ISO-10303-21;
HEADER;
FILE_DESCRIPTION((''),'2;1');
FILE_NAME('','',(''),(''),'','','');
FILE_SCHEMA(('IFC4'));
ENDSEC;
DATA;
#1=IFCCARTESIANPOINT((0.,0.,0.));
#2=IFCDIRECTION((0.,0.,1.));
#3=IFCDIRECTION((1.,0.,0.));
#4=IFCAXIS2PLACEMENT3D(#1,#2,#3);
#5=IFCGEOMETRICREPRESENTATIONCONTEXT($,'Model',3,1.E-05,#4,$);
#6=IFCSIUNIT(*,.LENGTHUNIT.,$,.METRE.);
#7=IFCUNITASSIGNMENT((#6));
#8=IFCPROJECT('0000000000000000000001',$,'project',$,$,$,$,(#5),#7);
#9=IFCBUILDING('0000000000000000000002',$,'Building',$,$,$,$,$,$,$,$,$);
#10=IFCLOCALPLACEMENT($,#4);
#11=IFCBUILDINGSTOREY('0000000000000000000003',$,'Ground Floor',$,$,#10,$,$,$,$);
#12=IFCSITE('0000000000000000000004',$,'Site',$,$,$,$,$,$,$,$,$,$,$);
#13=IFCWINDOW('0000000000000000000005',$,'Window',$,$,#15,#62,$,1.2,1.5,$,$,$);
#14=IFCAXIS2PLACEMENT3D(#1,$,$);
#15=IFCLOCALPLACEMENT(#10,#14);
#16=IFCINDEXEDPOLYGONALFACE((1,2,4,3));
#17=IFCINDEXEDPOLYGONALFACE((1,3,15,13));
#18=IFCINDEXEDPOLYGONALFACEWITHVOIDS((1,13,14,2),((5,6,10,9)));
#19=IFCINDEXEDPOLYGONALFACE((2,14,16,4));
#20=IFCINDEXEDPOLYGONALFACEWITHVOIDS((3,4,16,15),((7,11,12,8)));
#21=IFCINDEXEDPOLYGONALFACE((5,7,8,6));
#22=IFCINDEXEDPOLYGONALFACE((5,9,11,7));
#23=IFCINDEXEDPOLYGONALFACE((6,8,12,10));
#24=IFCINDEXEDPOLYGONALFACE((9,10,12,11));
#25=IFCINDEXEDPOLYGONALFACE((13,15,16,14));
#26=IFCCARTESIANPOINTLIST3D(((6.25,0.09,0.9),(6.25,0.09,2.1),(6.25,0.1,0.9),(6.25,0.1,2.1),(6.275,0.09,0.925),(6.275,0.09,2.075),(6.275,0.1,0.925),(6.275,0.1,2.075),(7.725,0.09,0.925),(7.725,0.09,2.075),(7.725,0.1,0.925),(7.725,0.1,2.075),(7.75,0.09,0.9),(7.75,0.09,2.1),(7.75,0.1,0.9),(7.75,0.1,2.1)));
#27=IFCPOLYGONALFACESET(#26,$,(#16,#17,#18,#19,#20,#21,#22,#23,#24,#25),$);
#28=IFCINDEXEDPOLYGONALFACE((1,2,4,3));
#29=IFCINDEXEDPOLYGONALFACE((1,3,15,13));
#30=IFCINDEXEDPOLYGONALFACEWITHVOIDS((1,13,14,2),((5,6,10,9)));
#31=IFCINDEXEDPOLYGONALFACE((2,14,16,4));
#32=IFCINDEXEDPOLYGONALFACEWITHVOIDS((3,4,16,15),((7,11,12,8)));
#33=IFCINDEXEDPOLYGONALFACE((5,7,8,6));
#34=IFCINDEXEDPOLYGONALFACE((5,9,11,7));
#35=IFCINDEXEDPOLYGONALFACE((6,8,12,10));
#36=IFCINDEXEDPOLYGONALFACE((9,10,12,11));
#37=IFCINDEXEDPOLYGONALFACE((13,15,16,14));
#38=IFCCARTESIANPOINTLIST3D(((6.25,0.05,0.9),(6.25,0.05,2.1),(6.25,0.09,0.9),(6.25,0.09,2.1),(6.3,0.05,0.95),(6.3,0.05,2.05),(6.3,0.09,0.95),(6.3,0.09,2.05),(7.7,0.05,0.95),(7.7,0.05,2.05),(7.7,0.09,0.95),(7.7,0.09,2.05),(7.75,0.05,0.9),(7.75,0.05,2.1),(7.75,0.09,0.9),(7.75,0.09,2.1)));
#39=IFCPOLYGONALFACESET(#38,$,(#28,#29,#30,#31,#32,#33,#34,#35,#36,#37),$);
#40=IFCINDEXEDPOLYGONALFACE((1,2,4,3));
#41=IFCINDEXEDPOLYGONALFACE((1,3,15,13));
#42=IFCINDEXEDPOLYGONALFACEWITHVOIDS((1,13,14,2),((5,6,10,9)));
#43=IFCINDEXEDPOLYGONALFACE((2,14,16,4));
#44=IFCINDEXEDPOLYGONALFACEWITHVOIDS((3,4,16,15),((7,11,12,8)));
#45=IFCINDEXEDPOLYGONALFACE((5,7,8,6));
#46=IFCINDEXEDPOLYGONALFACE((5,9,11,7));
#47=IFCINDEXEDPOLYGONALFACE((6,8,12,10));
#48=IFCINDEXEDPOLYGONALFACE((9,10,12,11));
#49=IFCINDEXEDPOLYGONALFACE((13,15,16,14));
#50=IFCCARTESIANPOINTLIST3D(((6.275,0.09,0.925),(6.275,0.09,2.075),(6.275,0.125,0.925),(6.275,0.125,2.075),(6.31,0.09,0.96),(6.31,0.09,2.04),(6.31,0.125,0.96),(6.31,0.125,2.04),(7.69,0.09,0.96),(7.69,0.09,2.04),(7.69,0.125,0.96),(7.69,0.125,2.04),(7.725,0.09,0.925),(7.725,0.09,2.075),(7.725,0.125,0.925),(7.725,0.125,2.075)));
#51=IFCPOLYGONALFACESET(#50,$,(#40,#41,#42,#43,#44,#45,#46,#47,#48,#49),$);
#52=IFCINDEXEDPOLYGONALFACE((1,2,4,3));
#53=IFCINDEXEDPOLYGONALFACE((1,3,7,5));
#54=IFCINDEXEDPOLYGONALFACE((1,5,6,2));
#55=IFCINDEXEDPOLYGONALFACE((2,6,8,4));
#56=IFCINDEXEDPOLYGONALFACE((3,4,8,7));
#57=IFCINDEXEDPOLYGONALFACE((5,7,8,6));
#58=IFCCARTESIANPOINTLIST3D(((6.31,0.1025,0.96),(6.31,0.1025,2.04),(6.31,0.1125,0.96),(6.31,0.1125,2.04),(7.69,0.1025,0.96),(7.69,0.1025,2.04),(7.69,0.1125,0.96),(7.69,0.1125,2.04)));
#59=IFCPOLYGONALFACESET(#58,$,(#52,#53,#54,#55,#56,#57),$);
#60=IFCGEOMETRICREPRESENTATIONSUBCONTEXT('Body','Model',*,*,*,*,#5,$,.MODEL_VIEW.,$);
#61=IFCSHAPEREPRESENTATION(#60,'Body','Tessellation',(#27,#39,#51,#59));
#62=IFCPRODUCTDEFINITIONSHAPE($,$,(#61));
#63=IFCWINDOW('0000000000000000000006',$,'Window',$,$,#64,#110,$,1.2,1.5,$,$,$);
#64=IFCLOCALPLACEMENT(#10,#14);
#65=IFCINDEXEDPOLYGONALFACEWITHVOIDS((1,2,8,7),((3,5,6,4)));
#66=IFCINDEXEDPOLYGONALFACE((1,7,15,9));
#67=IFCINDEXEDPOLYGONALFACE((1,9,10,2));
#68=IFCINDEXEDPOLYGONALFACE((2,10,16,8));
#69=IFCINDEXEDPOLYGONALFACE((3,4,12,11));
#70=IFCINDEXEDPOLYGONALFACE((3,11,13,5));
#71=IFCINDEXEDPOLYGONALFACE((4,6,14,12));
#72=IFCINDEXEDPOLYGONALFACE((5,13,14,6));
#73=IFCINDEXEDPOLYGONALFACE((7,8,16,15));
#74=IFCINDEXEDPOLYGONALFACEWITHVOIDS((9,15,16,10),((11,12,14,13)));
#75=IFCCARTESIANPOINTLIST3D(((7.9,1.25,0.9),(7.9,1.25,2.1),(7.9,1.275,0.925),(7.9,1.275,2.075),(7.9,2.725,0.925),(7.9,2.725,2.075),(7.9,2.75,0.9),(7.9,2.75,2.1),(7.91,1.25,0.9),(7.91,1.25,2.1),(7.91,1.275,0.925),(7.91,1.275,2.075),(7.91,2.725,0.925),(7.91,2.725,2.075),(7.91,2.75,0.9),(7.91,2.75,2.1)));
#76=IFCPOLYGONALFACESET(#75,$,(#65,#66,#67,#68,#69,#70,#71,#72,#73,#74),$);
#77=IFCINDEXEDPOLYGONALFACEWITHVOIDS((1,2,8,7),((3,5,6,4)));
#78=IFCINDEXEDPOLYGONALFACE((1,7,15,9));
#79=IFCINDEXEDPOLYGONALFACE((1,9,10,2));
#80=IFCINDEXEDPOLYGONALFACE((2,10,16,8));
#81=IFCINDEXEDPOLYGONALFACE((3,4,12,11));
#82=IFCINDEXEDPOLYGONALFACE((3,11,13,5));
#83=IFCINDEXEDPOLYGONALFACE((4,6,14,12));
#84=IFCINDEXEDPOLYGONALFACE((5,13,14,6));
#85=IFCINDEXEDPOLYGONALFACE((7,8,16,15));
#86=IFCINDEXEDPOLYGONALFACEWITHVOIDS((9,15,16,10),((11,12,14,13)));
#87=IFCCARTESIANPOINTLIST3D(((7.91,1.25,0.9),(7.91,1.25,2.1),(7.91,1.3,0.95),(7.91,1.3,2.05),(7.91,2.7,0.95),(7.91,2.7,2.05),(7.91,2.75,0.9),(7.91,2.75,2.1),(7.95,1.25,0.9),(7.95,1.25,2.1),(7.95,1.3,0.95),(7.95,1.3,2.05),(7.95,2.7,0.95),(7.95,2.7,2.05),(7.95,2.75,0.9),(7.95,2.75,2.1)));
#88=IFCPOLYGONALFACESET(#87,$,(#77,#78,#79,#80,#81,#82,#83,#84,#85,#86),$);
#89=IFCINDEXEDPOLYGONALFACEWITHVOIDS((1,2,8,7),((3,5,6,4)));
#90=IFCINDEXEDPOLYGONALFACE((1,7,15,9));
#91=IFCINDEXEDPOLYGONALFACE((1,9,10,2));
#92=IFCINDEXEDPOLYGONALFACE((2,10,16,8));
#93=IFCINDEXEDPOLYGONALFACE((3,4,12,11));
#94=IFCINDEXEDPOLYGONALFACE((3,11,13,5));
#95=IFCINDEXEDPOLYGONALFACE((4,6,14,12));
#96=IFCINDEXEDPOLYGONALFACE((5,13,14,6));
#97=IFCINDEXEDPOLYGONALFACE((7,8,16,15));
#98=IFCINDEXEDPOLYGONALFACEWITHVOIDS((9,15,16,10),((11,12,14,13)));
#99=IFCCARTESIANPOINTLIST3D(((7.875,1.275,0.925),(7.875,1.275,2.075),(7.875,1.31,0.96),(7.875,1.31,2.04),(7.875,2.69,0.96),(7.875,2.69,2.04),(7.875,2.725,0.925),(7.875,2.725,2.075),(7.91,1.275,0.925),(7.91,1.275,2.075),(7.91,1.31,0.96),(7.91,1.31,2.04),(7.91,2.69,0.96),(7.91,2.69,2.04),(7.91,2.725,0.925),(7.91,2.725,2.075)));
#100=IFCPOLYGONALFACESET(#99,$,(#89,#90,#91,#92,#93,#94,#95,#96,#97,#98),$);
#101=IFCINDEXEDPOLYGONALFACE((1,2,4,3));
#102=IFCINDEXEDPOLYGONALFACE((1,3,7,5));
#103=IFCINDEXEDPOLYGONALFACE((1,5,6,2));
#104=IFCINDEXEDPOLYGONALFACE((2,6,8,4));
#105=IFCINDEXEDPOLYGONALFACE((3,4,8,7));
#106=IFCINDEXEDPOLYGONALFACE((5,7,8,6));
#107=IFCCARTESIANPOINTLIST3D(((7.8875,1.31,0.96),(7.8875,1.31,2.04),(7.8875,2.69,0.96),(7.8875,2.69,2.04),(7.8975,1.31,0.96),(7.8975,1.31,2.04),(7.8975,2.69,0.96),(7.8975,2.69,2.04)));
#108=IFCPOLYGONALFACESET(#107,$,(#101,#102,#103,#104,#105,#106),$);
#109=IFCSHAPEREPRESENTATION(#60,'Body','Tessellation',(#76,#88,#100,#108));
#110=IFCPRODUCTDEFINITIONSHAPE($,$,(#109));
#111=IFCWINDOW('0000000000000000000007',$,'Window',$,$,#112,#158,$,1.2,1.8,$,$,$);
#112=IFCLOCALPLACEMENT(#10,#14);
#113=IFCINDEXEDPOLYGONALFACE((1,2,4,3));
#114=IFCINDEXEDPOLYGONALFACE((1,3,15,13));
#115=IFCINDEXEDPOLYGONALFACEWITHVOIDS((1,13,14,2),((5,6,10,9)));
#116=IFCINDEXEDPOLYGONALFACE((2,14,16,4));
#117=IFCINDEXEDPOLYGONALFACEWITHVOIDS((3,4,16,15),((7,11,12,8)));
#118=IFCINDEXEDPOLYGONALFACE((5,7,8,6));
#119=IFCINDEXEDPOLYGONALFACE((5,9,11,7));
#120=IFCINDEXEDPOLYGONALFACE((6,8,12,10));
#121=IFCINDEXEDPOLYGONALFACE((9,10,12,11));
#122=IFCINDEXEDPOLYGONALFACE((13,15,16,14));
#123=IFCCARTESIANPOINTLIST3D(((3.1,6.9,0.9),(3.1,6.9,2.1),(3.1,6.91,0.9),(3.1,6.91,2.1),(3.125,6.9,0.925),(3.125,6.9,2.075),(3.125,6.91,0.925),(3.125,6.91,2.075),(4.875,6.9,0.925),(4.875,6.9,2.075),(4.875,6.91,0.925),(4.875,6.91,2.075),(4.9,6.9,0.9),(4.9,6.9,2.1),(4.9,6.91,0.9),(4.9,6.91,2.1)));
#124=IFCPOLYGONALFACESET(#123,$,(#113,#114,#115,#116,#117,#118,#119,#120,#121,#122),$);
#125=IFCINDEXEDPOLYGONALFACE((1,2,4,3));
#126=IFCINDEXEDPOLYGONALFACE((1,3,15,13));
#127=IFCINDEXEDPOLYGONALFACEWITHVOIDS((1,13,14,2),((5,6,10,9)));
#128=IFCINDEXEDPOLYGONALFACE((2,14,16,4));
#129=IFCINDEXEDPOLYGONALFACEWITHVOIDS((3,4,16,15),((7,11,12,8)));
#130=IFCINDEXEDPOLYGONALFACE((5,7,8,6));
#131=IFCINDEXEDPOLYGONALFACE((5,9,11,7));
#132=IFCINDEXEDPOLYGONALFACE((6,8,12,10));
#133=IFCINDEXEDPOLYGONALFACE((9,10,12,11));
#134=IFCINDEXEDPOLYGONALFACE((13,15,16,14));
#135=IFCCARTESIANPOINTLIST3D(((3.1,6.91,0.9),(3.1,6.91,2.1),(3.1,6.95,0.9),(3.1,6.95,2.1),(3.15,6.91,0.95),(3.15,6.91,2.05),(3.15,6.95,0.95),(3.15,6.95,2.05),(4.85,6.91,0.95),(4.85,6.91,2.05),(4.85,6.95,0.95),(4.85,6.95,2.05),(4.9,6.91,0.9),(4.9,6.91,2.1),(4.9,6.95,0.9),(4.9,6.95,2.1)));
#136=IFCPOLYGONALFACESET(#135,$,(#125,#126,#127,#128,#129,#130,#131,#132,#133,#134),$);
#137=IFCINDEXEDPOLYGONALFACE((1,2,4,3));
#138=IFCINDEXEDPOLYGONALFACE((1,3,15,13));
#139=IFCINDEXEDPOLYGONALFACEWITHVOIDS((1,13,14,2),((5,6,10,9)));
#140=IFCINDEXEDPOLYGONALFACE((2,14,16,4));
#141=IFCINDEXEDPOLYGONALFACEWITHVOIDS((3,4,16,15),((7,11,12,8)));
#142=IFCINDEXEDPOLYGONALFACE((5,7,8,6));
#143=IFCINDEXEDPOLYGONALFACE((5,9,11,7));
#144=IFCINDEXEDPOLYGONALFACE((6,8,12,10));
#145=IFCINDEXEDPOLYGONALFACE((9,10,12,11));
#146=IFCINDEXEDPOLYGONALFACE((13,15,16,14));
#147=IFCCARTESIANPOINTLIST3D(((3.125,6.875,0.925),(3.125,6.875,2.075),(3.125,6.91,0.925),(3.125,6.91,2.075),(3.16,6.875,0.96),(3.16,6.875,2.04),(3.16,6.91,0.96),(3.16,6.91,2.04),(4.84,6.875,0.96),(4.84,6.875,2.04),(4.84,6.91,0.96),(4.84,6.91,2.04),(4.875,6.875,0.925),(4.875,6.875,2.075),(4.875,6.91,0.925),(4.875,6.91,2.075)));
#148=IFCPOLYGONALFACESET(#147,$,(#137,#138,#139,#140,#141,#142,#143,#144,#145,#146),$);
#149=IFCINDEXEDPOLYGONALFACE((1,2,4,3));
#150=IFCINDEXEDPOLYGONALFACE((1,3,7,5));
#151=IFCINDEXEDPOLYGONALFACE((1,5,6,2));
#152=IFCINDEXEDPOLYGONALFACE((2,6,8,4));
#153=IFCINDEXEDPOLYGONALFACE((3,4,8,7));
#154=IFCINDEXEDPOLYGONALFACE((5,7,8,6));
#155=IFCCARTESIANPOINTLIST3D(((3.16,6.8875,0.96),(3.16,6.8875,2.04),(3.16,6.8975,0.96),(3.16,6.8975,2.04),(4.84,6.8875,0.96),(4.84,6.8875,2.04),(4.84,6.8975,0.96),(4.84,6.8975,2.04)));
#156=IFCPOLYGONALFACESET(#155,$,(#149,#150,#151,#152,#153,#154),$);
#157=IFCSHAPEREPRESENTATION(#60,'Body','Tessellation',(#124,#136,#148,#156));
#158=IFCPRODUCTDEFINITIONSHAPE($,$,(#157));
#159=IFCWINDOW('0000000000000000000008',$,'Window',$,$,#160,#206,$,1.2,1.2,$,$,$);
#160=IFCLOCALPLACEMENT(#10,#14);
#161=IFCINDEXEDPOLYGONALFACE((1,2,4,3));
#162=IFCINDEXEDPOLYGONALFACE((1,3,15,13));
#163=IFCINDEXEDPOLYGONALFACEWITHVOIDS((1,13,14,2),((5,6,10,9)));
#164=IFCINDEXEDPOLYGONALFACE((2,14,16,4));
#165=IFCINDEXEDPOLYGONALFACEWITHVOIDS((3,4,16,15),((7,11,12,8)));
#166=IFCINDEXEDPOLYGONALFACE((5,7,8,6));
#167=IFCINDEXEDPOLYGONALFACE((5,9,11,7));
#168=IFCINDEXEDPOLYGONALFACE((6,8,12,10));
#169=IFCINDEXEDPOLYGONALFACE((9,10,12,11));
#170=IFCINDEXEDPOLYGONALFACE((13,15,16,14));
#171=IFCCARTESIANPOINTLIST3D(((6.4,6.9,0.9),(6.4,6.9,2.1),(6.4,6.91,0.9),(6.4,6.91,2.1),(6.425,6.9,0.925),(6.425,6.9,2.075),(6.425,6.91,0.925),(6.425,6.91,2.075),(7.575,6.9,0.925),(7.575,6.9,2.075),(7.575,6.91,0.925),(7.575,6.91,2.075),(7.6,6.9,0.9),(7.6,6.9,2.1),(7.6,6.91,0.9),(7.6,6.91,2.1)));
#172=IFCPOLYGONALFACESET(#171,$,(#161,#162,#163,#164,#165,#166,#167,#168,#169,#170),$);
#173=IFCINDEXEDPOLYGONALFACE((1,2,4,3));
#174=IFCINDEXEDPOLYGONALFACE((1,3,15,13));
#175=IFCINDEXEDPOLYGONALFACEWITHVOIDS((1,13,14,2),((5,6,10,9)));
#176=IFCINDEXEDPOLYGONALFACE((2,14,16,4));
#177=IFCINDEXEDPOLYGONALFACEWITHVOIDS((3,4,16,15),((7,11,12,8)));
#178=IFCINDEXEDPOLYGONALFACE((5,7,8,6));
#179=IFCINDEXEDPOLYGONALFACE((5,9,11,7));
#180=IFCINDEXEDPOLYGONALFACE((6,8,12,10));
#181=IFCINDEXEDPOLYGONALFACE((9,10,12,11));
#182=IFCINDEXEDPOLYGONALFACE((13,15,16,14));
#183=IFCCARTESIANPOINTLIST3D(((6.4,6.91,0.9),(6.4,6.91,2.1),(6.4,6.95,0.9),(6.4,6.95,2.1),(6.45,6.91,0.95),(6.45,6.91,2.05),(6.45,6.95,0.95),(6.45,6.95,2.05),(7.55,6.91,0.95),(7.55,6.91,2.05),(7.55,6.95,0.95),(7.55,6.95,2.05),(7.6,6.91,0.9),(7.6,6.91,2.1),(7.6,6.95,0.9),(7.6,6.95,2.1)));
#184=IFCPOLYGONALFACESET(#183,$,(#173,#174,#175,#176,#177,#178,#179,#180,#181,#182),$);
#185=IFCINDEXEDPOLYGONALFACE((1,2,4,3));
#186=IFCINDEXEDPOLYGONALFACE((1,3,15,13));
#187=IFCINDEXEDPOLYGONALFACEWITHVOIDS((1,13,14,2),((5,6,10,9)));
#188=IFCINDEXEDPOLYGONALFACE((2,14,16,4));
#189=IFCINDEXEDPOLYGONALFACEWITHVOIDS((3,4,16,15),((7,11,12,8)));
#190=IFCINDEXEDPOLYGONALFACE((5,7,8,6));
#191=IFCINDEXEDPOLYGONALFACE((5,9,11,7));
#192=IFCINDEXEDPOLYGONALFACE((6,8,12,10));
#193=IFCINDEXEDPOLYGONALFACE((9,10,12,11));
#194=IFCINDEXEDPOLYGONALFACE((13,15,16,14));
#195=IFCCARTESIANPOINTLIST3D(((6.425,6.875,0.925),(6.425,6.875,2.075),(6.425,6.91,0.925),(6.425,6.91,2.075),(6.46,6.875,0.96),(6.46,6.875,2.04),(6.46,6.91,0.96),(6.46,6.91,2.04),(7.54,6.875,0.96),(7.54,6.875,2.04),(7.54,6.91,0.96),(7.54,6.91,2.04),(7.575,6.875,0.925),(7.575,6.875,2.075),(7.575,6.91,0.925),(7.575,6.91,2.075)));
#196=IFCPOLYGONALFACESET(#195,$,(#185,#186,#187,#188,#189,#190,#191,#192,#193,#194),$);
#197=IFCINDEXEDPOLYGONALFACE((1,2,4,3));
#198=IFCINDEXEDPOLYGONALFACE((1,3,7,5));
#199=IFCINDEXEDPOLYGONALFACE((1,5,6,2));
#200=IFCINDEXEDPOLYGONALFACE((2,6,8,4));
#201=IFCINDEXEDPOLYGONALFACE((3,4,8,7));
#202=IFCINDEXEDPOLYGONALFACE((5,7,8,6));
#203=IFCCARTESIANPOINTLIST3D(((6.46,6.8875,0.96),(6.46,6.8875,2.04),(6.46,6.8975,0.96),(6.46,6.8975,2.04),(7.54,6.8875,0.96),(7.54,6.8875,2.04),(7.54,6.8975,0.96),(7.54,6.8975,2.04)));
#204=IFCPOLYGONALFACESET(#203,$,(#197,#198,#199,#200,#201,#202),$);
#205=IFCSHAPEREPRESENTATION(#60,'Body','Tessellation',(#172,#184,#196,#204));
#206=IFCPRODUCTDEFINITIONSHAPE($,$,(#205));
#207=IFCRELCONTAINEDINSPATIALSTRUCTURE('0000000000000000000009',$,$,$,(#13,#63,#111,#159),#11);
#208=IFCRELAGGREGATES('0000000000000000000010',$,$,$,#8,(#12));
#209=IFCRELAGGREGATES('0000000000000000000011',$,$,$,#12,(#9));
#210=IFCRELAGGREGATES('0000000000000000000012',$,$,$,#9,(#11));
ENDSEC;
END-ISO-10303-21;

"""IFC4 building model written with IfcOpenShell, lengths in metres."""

from ifc_helpers import new_model, si_unit, frame, origin_with_axes, place, context, subcontext, project, spatial, line, indexed_curve, outline, extrude, element, save


model = new_model("IFC4")

# Units and contexts
model_context = context("Model", 3, precision=1e-05, world=origin_with_axes())
body_context = subcontext(model_context, "Body", "Model", "MODEL_VIEW")
ifc_project = project(units=[si_unit("LENGTHUNIT", "METRE")], contexts=[model_context])

# Site, building, storey
site = spatial("IfcSite", under=ifc_project, Name="Site")
building = spatial("IfcBuilding", under=site, Name="Building")
storey_placement = place(None, origin_with_axes())
storey = spatial("IfcBuildingStorey", under=building, at=storey_placement, Name="Ground Floor")

# Windows
for number, where, z_axis, x_axis, name in (
    (1, (6.25, 0.0, 0.9), (0.0, 0.0, 1.0), (1.0, 0.0, 0.0), "Window"),
    (2, (8.0, 1.25, 0.9), (0.0, 0.0, 1.0), (0.0, 1.0, 0.0), "Window"),
):
    element("IfcWindow", number, at=place(storey_placement, frame(where, z_axis=z_axis, x_axis=x_axis)), inside=storey, Name=name, OverallHeight=1.2, OverallWidth=1.5, context=body_context, shape_type="SweptSolid", body=[
        extrude(outline(indexed_curve([(0.0, 0.0), (1.5, 0.0), (1.5, 1.2), (0.0, 1.2)], segments=[line(1, 2, 3, 4, 1)]), holes=[indexed_curve([(0.025, 0.025), (1.475, 0.025), (1.475, 1.175), (0.025, 1.175)], segments=[line(1, 2, 3, 4, 1)])]), frame((0.0, 0.09, 0.0), z_axis=(0.0, -1.0, 0.0), x_axis=(1.0, 0.0, 0.0)), (0.0, 0.0, -1.0), 0.01),
        extrude(outline(indexed_curve([(0.0, 0.0), (1.5, 0.0), (1.5, 1.2), (0.0, 1.2)], segments=[line(1, 2, 3, 4, 1)]), holes=[indexed_curve([(0.05, 0.05), (1.45, 0.05), (1.45, 1.15), (0.05, 1.15)], segments=[line(1, 2, 3, 4, 1)])]), frame((0.0, 0.05, 0.0), z_axis=(0.0, -1.0, 0.0), x_axis=(1.0, 0.0, 0.0)), (0.0, 0.0, -1.0), 0.04),
        extrude(outline(indexed_curve([(0.0, 0.0), (1.45, 0.0), (1.45, 1.15), (0.0, 1.15)], segments=[line(1, 2, 3, 4, 1)]), holes=[indexed_curve([(0.035, 0.035), (1.415, 0.035), (1.415, 1.115), (0.035, 1.115)], segments=[line(1, 2, 3, 4, 1)])]), frame((0.025, 0.09, 0.025), z_axis=(0.0, -1.0, 0.0), x_axis=(1.0, 0.0, 0.0)), (0.0, 0.0, -1.0), 0.035),
        extrude(outline(indexed_curve([(0.035, 0.035), (1.415, 0.035), (1.415, 1.115), (0.035, 1.115)], segments=[line(1, 2, 3, 4, 1)])), frame((0.025, 0.1025, 0.025), z_axis=(0.0, -1.0, 0.0), x_axis=(1.0, 0.0, 0.0)), (0.0, 0.0, -1.0), 0.01),
    ])
window_placement = place(storey_placement, frame((4.9, 7.0, 0.9), z_axis=(0.0, 0.0, 1.0), x_axis=(-1.0, 0.0, 0.0)))
element("IfcWindow", 3, at=window_placement, inside=storey, Name="Window", OverallHeight=1.2, OverallWidth=1.8, context=body_context, shape_type="SweptSolid", body=[
    extrude(outline(indexed_curve([(0.0, 0.0), (1.8, 0.0), (1.8, 1.2), (0.0, 1.2)], segments=[line(1, 2, 3, 4, 1)]), holes=[indexed_curve([(0.025, 0.025), (1.775, 0.025), (1.775, 1.175), (0.025, 1.175)], segments=[line(1, 2, 3, 4, 1)])]), frame((0.0, 0.09, 0.0), z_axis=(0.0, -1.0, 0.0), x_axis=(1.0, 0.0, 0.0)), (0.0, 0.0, -1.0), 0.01),
    extrude(outline(indexed_curve([(0.0, 0.0), (1.8, 0.0), (1.8, 1.2), (0.0, 1.2)], segments=[line(1, 2, 3, 4, 1)]), holes=[indexed_curve([(0.05, 0.05), (1.75, 0.05), (1.75, 1.15), (0.05, 1.15)], segments=[line(1, 2, 3, 4, 1)])]), frame((0.0, 0.05, 0.0), z_axis=(0.0, -1.0, 0.0), x_axis=(1.0, 0.0, 0.0)), (0.0, 0.0, -1.0), 0.04),
    extrude(outline(indexed_curve([(0.0, 0.0), (1.75, 0.0), (1.75, 1.15), (0.0, 1.15)], segments=[line(1, 2, 3, 4, 1)]), holes=[indexed_curve([(0.035, 0.035), (1.715, 0.035), (1.715, 1.115), (0.035, 1.115)], segments=[line(1, 2, 3, 4, 1)])]), frame((0.025, 0.09, 0.025), z_axis=(0.0, -1.0, 0.0), x_axis=(1.0, 0.0, 0.0)), (0.0, 0.0, -1.0), 0.035),
    extrude(outline(indexed_curve([(0.035, 0.035), (1.715, 0.035), (1.715, 1.115), (0.035, 1.115)], segments=[line(1, 2, 3, 4, 1)])), frame((0.025, 0.1025, 0.025), z_axis=(0.0, -1.0, 0.0), x_axis=(1.0, 0.0, 0.0)), (0.0, 0.0, -1.0), 0.01),
])
for number, where, z_axis, x_axis, name in (
    (4, (7.6, 7.0, 0.9), (0.0, 0.0, 1.0), (-1.0, 0.0, 0.0), "Window"),
):
    element("IfcWindow", number, at=place(storey_placement, frame(where, z_axis=z_axis, x_axis=x_axis)), inside=storey, Name=name, OverallHeight=1.2, OverallWidth=1.2, context=body_context, shape_type="SweptSolid", body=[
        extrude(outline(indexed_curve([(0.0, 0.0), (1.2, 0.0), (1.2, 1.2), (0.0, 1.2)], segments=[line(1, 2, 3, 4, 1)]), holes=[indexed_curve([(0.025, 0.025), (1.175, 0.025), (1.175, 1.175), (0.025, 1.175)], segments=[line(1, 2, 3, 4, 1)])]), frame((0.0, 0.09, 0.0), z_axis=(0.0, -1.0, 0.0), x_axis=(1.0, 0.0, 0.0)), (0.0, 0.0, -1.0), 0.01),
        extrude(outline(indexed_curve([(0.0, 0.0), (1.2, 0.0), (1.2, 1.2), (0.0, 1.2)], segments=[line(1, 2, 3, 4, 1)]), holes=[indexed_curve([(0.05, 0.05), (1.15, 0.05), (1.15, 1.15), (0.05, 1.15)], segments=[line(1, 2, 3, 4, 1)])]), frame((0.0, 0.05, 0.0), z_axis=(0.0, -1.0, 0.0), x_axis=(1.0, 0.0, 0.0)), (0.0, 0.0, -1.0), 0.04),
        extrude(outline(indexed_curve([(0.0, 0.0), (1.15, 0.0), (1.15, 1.15), (0.0, 1.15)], segments=[line(1, 2, 3, 4, 1)]), holes=[indexed_curve([(0.035, 0.035), (1.115, 0.035), (1.115, 1.115), (0.035, 1.115)], segments=[line(1, 2, 3, 4, 1)])]), frame((0.025, 0.09, 0.025), z_axis=(0.0, -1.0, 0.0), x_axis=(1.0, 0.0, 0.0)), (0.0, 0.0, -1.0), 0.035),
        extrude(outline(indexed_curve([(0.035, 0.035), (1.115, 0.035), (1.115, 1.115), (0.035, 1.115)], segments=[line(1, 2, 3, 4, 1)])), frame((0.025, 0.1025, 0.025), z_axis=(0.0, -1.0, 0.0), x_axis=(1.0, 0.0, 0.0)), (0.0, 0.0, -1.0), 0.01),
    ])

save(model, "model.ifc")
